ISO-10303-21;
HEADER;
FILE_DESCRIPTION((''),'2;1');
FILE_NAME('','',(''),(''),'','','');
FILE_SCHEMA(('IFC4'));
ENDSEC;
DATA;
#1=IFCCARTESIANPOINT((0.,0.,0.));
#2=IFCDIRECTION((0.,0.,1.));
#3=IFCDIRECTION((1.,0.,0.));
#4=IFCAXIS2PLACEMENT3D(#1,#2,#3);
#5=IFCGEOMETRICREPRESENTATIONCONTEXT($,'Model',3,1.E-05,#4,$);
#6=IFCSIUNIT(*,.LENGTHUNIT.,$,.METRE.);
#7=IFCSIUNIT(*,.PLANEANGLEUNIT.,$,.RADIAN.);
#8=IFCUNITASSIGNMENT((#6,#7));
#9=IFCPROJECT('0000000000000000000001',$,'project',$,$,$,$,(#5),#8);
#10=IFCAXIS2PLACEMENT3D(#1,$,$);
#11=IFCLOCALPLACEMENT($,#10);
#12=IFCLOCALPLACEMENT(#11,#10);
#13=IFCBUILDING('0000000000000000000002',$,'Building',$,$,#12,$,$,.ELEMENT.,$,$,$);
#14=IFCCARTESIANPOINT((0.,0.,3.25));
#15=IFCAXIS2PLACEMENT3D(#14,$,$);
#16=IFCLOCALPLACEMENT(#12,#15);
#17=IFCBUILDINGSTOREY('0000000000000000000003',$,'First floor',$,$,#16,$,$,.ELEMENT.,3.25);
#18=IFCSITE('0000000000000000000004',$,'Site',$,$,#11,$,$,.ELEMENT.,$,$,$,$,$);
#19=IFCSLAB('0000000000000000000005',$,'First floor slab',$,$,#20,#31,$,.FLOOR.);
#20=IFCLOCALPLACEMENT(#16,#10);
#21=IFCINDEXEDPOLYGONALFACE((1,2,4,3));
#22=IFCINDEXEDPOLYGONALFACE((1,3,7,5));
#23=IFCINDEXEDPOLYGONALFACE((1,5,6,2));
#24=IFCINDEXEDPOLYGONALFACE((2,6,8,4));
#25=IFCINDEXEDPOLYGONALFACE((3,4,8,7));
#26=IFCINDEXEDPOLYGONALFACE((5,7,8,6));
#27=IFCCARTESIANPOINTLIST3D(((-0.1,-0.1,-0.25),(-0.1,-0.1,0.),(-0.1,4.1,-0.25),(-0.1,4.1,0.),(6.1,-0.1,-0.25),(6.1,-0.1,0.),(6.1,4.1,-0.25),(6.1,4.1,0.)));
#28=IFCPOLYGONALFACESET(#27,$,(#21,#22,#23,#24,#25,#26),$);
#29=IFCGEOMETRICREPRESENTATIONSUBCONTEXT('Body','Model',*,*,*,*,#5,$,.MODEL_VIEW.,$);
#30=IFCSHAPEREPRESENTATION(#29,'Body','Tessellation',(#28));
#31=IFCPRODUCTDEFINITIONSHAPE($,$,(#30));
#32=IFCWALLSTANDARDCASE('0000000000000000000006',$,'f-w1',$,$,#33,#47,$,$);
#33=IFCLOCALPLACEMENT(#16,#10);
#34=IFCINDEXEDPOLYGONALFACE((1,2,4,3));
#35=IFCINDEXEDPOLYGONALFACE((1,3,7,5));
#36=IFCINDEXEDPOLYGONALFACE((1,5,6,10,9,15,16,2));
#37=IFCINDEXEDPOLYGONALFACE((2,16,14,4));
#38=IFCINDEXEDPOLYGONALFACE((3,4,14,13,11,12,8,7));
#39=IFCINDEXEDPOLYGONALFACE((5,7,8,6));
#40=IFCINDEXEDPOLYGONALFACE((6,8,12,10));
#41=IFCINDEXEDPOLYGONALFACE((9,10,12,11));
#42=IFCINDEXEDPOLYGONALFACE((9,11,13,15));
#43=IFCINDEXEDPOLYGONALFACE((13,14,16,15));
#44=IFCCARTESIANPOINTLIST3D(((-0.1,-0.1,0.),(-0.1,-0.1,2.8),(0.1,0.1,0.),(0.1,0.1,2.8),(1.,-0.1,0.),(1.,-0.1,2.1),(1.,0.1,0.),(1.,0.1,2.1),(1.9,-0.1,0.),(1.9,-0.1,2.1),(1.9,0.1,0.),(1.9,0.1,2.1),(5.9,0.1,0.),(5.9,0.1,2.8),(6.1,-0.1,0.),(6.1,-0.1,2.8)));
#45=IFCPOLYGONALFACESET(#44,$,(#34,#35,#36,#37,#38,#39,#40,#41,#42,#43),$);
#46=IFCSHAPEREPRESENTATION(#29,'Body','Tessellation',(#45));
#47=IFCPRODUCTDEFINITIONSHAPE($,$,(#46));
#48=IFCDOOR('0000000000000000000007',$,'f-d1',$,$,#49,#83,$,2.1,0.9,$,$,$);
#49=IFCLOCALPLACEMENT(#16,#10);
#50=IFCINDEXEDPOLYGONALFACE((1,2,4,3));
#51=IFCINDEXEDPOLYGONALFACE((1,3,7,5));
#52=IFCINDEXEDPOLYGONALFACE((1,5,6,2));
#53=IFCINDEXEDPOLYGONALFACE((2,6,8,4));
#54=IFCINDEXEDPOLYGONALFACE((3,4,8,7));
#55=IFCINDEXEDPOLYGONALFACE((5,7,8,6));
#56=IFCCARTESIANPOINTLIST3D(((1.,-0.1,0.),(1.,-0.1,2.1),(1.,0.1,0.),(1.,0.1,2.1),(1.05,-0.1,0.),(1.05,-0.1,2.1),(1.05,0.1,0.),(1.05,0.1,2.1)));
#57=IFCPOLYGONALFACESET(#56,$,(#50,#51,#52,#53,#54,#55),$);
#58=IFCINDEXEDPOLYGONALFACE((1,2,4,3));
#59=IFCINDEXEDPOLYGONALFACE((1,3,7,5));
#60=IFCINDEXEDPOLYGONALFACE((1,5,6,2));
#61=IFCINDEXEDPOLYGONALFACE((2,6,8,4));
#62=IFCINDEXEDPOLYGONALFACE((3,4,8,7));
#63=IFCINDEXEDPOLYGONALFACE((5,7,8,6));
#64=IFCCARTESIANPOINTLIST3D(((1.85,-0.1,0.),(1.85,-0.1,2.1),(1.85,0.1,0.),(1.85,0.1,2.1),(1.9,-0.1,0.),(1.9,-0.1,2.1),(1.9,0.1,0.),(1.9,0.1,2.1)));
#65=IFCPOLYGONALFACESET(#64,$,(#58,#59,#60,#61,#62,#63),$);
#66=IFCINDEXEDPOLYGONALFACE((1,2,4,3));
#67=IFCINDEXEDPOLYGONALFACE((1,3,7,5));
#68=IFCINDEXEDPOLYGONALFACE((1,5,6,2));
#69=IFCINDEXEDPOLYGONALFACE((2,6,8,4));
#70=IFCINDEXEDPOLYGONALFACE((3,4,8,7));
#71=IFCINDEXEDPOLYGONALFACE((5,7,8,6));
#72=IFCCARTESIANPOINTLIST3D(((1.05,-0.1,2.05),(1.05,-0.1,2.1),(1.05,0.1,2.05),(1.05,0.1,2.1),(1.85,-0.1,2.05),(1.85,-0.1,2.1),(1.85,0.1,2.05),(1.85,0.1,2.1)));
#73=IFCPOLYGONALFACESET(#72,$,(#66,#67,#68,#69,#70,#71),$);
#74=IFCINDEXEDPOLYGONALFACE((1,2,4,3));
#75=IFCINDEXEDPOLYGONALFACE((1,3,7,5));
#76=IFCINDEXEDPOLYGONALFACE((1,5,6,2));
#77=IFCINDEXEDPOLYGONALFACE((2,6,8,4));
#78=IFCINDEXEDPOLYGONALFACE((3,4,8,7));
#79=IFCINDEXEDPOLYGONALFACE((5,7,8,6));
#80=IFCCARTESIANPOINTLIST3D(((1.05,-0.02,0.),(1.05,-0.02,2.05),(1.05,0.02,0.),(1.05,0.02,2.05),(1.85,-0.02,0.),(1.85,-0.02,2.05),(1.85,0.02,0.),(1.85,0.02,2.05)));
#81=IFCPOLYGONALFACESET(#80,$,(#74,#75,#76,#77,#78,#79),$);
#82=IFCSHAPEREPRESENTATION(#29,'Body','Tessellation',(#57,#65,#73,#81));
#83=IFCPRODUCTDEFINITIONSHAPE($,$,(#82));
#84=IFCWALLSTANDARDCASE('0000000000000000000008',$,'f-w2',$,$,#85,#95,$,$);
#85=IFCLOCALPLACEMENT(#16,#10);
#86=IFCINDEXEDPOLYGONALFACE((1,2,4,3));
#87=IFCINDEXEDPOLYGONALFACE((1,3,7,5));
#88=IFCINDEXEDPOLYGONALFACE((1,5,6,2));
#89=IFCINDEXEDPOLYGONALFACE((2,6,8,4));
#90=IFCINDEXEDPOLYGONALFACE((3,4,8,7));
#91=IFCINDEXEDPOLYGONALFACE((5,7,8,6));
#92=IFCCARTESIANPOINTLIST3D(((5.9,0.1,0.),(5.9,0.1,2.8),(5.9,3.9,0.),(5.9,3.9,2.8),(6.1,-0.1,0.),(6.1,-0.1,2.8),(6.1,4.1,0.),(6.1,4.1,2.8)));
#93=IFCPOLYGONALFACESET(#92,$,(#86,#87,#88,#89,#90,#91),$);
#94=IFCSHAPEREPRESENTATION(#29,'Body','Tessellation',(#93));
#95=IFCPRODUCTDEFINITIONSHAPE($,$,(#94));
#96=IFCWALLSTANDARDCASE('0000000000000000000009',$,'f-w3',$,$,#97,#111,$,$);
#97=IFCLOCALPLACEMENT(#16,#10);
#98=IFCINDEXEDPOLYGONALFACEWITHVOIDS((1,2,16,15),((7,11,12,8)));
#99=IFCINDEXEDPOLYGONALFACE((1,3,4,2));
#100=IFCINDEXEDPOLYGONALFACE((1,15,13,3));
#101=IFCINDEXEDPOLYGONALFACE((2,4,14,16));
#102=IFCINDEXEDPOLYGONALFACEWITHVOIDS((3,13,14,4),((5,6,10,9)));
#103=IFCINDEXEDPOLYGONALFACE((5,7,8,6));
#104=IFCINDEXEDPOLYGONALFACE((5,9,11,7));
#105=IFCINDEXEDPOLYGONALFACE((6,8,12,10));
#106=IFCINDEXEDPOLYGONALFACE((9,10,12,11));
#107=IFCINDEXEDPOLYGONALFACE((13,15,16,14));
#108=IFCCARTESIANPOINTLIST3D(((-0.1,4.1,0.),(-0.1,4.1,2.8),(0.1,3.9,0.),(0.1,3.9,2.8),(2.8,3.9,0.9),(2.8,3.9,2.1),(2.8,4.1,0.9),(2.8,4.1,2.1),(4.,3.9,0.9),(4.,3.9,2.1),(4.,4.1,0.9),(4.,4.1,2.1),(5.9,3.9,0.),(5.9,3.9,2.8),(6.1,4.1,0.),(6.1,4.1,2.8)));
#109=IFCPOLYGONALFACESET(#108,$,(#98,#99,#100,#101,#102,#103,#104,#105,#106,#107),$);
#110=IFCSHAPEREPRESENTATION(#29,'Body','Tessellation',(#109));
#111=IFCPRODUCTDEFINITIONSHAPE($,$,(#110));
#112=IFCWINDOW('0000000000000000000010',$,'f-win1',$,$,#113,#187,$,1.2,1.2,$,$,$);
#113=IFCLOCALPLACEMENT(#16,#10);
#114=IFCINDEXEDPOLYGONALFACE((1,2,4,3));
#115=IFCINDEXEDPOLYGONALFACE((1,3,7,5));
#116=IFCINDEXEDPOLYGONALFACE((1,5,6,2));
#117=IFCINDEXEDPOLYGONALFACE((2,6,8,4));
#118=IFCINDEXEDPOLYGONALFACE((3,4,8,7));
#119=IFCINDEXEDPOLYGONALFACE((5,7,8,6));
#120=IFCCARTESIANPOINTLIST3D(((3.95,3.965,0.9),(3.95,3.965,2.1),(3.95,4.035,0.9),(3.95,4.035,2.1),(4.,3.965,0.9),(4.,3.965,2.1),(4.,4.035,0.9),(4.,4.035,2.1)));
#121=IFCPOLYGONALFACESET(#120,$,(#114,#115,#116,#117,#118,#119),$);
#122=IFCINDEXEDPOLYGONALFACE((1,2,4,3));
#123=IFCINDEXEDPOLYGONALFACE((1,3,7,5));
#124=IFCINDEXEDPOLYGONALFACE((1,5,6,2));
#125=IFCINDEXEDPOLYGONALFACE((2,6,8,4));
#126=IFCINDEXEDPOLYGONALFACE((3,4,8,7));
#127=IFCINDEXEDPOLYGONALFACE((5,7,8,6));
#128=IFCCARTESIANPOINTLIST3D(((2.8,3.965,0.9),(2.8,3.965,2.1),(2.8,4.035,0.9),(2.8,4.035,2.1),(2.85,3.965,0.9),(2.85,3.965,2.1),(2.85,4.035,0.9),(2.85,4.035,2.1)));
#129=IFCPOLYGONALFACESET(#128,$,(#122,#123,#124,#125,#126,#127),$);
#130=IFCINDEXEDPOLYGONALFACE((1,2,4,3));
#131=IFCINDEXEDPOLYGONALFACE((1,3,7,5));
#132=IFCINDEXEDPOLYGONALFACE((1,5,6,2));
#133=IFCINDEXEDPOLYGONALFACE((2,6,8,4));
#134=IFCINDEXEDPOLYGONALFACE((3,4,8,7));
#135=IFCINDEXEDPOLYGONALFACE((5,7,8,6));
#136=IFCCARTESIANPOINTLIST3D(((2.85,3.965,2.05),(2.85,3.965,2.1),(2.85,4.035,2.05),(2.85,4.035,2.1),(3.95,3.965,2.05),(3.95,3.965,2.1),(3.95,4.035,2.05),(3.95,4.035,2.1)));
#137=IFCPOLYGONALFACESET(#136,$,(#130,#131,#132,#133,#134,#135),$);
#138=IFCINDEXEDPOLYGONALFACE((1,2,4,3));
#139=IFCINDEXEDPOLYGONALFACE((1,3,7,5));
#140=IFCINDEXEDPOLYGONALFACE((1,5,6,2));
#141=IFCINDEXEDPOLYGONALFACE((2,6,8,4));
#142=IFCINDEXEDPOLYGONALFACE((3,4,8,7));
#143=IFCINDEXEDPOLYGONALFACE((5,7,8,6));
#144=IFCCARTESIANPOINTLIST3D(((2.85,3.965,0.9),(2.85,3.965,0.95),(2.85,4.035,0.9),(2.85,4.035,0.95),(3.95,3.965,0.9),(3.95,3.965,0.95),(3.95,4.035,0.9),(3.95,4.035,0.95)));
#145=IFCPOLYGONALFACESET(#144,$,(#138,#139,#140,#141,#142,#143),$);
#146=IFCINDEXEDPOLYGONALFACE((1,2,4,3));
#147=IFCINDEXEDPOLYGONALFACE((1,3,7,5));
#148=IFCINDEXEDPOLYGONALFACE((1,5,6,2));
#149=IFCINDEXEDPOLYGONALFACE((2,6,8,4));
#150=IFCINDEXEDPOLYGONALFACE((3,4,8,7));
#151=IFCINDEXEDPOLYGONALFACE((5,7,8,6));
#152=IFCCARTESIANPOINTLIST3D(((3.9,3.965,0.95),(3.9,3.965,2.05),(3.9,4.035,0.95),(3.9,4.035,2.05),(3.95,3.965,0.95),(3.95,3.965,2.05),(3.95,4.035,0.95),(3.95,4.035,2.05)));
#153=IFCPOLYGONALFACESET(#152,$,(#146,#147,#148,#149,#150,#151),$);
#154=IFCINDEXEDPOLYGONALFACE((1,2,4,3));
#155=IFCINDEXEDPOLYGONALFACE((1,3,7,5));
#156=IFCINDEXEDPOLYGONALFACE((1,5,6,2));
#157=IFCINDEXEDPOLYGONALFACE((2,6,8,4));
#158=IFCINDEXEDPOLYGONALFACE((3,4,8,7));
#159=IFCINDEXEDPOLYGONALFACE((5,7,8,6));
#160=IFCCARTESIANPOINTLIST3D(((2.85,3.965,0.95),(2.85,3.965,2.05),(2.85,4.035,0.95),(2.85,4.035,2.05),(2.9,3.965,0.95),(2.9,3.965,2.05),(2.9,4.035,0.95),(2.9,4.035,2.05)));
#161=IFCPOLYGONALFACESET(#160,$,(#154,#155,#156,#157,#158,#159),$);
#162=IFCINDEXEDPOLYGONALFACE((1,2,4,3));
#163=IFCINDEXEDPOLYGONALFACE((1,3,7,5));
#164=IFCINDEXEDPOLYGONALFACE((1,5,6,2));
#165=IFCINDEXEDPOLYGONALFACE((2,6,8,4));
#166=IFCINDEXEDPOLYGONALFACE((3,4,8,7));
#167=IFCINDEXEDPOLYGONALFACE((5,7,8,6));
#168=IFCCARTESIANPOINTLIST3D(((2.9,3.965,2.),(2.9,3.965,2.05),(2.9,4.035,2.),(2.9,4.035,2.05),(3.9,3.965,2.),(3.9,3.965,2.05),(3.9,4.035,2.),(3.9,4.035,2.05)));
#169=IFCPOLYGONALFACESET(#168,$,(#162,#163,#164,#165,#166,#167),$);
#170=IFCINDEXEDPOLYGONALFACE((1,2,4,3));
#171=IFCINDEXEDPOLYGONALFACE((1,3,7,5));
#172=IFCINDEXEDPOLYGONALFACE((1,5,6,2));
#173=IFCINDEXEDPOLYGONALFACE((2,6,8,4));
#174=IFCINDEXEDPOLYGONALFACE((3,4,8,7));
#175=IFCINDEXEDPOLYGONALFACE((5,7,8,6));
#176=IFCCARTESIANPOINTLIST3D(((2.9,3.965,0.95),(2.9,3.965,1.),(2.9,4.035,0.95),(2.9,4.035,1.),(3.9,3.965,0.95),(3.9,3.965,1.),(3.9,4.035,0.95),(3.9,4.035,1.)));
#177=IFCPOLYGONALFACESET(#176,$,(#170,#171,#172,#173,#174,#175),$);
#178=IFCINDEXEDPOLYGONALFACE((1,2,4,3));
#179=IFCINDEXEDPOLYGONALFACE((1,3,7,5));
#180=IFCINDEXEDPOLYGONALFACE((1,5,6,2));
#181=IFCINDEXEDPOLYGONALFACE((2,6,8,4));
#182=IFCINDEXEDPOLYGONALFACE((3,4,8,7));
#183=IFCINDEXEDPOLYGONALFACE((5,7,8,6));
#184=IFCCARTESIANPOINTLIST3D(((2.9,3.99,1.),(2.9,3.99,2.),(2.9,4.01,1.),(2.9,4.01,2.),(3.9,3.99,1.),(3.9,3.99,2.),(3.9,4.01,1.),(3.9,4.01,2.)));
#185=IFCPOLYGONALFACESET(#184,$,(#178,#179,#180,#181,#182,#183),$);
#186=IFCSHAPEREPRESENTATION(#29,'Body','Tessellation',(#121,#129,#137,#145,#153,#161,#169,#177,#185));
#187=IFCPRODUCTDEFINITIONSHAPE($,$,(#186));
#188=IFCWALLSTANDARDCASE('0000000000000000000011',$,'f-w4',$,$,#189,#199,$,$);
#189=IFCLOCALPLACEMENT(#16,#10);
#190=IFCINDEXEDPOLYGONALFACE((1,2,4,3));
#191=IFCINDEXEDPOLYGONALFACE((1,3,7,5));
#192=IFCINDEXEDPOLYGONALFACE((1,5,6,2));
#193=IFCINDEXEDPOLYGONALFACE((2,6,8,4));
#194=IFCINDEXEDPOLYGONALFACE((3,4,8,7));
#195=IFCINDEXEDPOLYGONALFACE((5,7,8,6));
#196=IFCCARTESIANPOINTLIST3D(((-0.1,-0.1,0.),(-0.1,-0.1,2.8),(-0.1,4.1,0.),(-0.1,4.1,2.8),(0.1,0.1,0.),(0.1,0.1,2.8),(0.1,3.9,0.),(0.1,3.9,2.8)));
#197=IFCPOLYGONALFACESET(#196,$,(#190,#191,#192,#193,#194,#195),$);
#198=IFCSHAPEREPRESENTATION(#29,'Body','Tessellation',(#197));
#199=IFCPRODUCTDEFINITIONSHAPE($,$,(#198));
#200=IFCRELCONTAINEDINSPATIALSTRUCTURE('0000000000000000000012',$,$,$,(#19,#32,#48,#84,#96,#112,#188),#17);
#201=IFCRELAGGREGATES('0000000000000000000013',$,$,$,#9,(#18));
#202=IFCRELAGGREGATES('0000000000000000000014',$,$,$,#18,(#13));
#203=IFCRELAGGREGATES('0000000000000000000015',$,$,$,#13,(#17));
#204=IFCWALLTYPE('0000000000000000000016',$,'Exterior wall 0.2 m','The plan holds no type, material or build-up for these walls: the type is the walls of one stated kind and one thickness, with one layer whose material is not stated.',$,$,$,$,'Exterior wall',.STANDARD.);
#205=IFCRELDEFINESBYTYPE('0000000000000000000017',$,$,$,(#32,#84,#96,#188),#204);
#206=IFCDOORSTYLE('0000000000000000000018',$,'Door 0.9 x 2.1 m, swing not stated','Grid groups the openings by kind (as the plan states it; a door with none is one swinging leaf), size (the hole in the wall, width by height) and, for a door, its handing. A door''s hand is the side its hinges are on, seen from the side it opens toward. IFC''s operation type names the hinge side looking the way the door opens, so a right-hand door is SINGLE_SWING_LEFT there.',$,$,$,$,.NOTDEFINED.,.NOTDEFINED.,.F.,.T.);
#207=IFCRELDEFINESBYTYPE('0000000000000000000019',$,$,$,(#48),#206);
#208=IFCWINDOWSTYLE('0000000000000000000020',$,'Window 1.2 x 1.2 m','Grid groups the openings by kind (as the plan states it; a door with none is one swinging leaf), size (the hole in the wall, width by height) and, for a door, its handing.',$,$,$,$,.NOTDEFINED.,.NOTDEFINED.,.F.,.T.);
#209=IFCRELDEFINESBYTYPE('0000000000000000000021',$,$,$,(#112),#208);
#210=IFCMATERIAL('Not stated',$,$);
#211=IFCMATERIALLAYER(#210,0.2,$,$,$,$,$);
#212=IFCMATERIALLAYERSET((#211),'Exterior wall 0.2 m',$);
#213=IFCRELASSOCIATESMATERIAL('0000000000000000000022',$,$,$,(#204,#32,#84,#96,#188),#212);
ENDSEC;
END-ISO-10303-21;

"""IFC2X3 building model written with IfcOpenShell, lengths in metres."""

from ifc_helpers import new_model, si_unit, frame, frame_2d, origin, origin_with_axes, place, context, subcontext, project, spatial, polyline, rectangle, outline, extrude, material, layer, layer_set, layer_usage, type_object, element, fill, save


model = new_model("IFC2X3")

# Units and contexts
model_context = context("Model", 3, precision=1e-05, world=origin_with_axes())
body_context = subcontext(model_context, "Body", "Model", "MODEL_VIEW")
ifc_project = project(units=[si_unit("LENGTHUNIT", "METRE"), si_unit("PLANEANGLEUNIT", "RADIAN")], contexts=[model_context])

# Site, building, storey
site_placement = place(None, origin())
site = spatial("IfcSite", under=ifc_project, at=site_placement, Name="Site", CompositionType="ELEMENT")
building_placement = place(site_placement, origin())
building = spatial("IfcBuilding", under=site, at=building_placement, Name="Building", CompositionType="ELEMENT")
storey_placement = place(building_placement, frame((0.0, 0.0, 3.25)))
storey = spatial("IfcBuildingStorey", under=building, at=storey_placement, Name="First floor", CompositionType="ELEMENT", Elevation=3.25)

# Slab
slab_placement = place(storey_placement, frame((0.0, 0.0, -0.25)))
element("IfcSlab", 1, at=slab_placement, inside=storey, Name="First floor slab", PredefinedType="FLOOR", context=body_context, shape_type="SweptSolid", body=[
    extrude(outline(polyline([(-0.1, -0.1), (6.1, -0.1), (6.1, 4.1), (-0.1, 4.1), (-0.1, -0.1)])), origin(), (0.0, 0.0, 1.0), 0.25),
])

# Wall, opening, door
ifc_material = material(Name="Not stated")
ifc_layer = layer(ifc_material, 0.2)
ifc_layer_set = layer_set([ifc_layer], Name="Exterior wall 0.2 m")
ifc_layer_usage = layer_usage(ifc_layer_set, "AXIS2", "POSITIVE", -0.1)
wall_type = type_object("IfcWallType", Name="Exterior wall 0.2 m", Description="The plan holds no type, material or build-up for these walls: the type is the walls of one stated kind and one thickness, with one layer whose material is not stated.", ElementType="Exterior wall", PredefinedType="STANDARD", material=ifc_layer_set)
wall_1_placement = place(storey_placement, origin_with_axes())
wall_1 = element("IfcWallStandardCase", 2, at=wall_1_placement, inside=storey, type_object=wall_type, material=ifc_layer_usage, Name="f-w1", context=body_context, shape_type="SweptSolid", body=[
    extrude(outline(polyline([(-0.1, -0.1), (6.1, -0.1), (5.9, 0.1), (0.1, 0.1), (-0.1, -0.1)])), origin(), (0.0, 0.0, 1.0), 2.8),
])
opening_1_placement = place(wall_1_placement, frame((1.0, 0.0, 0.0)))
opening_1 = element("IfcOpeningElement", 3, at=opening_1_placement, cuts=wall_1, context=body_context, shape_type="SweptSolid", body=[
    extrude(rectangle(XDim=0.9, YDim=0.22, at=frame_2d((0.45, 0.0), x_axis=(1.0, 0.0))), origin(), (0.0, 0.0, 1.0), 2.1),
])
door_style = type_object("IfcDoorStyle", Name="Door 0.9 x 2.1 m, swing not stated", Description="Grid groups the openings by kind (as the plan states it; a door with none is one swinging leaf), size (the hole in the wall, width by height) and, for a door, its handing. A door's hand is the side its hinges are on, seen from the side it opens toward. IFC's operation type names the hinge side looking the way the door opens, so a right-hand door is SINGLE_SWING_LEFT there.", ConstructionType="NOTDEFINED", OperationType="NOTDEFINED", ParameterTakesPrecedence=False, Sizeable=True)
door_placement = place(opening_1_placement, origin())
door = element("IfcDoor", 4, at=door_placement, inside=storey, type_object=door_style, Name="f-d1", OverallHeight=2.1, OverallWidth=0.9, context=body_context, shape_type="SweptSolid", body=[
    extrude(rectangle(XDim=0.05, YDim=0.2, at=frame_2d((0.025, 0.0), x_axis=(1.0, 0.0))), origin(), (0.0, 0.0, 1.0), 2.1),
    extrude(rectangle(XDim=0.05, YDim=0.2, at=frame_2d((0.875, 0.0), x_axis=(1.0, 0.0))), origin(), (0.0, 0.0, 1.0), 2.1),
    extrude(rectangle(XDim=0.8, YDim=0.2, at=frame_2d((0.45, 0.0), x_axis=(1.0, 0.0))), frame((0.0, 0.0, 2.05)), (0.0, 0.0, 1.0), 0.05),
    extrude(rectangle(XDim=0.8, YDim=0.04, at=frame_2d((0.45, 0.0), x_axis=(1.0, 0.0))), origin(), (0.0, 0.0, 1.0), 2.05),
])
fill(opening_1, door)

# Wall
wall_2_placement = place(storey_placement, frame((6.0, 0.0, 0.0), z_axis=(0.0, 0.0, 1.0), x_axis=(0.0, 1.0, 0.0)))
element("IfcWallStandardCase", 5, at=wall_2_placement, inside=storey, type_object=wall_type, material=ifc_layer_usage, Name="f-w2", context=body_context, shape_type="SweptSolid", body=[
    extrude(outline(polyline([(-0.1, -0.1), (4.1, -0.1), (3.9, 0.1), (0.1, 0.1), (-0.1, -0.1)])), origin(), (0.0, 0.0, 1.0), 2.8),
])

# Wall, opening, window
wall_3_placement = place(storey_placement, frame((6.0, 4.0, 0.0), z_axis=(0.0, 0.0, 1.0), x_axis=(-1.0, 0.0, 0.0)))
wall_3 = element("IfcWallStandardCase", 6, at=wall_3_placement, inside=storey, type_object=wall_type, material=ifc_layer_usage, Name="f-w3", context=body_context, shape_type="SweptSolid", body=[
    extrude(outline(polyline([(-0.1, -0.1), (6.1, -0.1), (5.9, 0.1), (0.1, 0.1), (-0.1, -0.1)])), origin(), (0.0, 0.0, 1.0), 2.8),
])
opening_2_placement = place(wall_3_placement, frame((2.0, 0.0, 0.9)))
opening_2 = element("IfcOpeningElement", 7, at=opening_2_placement, cuts=wall_3, context=body_context, shape_type="SweptSolid", body=[
    extrude(rectangle(XDim=1.2, YDim=0.22, at=frame_2d((0.6, 0.0), x_axis=(1.0, 0.0))), origin(), (0.0, 0.0, 1.0), 1.2),
])
window_style = type_object("IfcWindowStyle", Name="Window 1.2 x 1.2 m", Description="Grid groups the openings by kind (as the plan states it; a door with none is one swinging leaf), size (the hole in the wall, width by height) and, for a door, its handing.", ConstructionType="NOTDEFINED", OperationType="NOTDEFINED", ParameterTakesPrecedence=False, Sizeable=True)
window_placement = place(opening_2_placement, origin())
window = element("IfcWindow", 8, at=window_placement, inside=storey, type_object=window_style, Name="f-win1", OverallHeight=1.2, OverallWidth=1.2, context=body_context, shape_type="SweptSolid", body=[
    extrude(rectangle(XDim=0.05, YDim=0.07, at=frame_2d((0.025, 0.0), x_axis=(1.0, 0.0))), origin(), (0.0, 0.0, 1.0), 1.2),
    extrude(rectangle(XDim=0.05, YDim=0.07, at=frame_2d((1.175, 0.0), x_axis=(1.0, 0.0))), origin(), (0.0, 0.0, 1.0), 1.2),
    extrude(rectangle(XDim=1.1, YDim=0.07, at=frame_2d((0.6, 0.0), x_axis=(1.0, 0.0))), frame((0.0, 0.0, 1.15)), (0.0, 0.0, 1.0), 0.05),
    extrude(rectangle(XDim=1.1, YDim=0.07, at=frame_2d((0.6, 0.0), x_axis=(1.0, 0.0))), origin(), (0.0, 0.0, 1.0), 0.05),
    extrude(rectangle(XDim=0.05, YDim=0.07, at=frame_2d((0.075, 0.0), x_axis=(1.0, 0.0))), frame((0.0, 0.0, 0.05)), (0.0, 0.0, 1.0), 1.1),
    extrude(rectangle(XDim=0.05, YDim=0.07, at=frame_2d((1.125, 0.0), x_axis=(1.0, 0.0))), frame((0.0, 0.0, 0.05)), (0.0, 0.0, 1.0), 1.1),
    extrude(rectangle(XDim=1.0, YDim=0.07, at=frame_2d((0.6, 0.0), x_axis=(1.0, 0.0))), frame((0.0, 0.0, 1.1)), (0.0, 0.0, 1.0), 0.05),
    extrude(rectangle(XDim=1.0, YDim=0.07, at=frame_2d((0.6, 0.0), x_axis=(1.0, 0.0))), frame((0.0, 0.0, 0.05)), (0.0, 0.0, 1.0), 0.05),
    extrude(rectangle(XDim=1.0, YDim=0.02, at=frame_2d((0.6, 0.0), x_axis=(1.0, 0.0))), frame((0.0, 0.0, 0.1)), (0.0, 0.0, 1.0), 1.0),
])
fill(opening_2, window)

# Wall
wall_4_placement = place(storey_placement, frame((0.0, 4.0, 0.0), z_axis=(0.0, 0.0, 1.0), x_axis=(0.0, -1.0, 0.0)))
element("IfcWallStandardCase", 9, at=wall_4_placement, inside=storey, type_object=wall_type, material=ifc_layer_usage, Name="f-w4", context=body_context, shape_type="SweptSolid", body=[
    extrude(outline(polyline([(-0.1, -0.1), (4.1, -0.1), (3.9, 0.1), (0.1, 0.1), (-0.1, -0.1)])), origin(), (0.0, 0.0, 1.0), 2.8),
])

save(model, "model.ifc")
